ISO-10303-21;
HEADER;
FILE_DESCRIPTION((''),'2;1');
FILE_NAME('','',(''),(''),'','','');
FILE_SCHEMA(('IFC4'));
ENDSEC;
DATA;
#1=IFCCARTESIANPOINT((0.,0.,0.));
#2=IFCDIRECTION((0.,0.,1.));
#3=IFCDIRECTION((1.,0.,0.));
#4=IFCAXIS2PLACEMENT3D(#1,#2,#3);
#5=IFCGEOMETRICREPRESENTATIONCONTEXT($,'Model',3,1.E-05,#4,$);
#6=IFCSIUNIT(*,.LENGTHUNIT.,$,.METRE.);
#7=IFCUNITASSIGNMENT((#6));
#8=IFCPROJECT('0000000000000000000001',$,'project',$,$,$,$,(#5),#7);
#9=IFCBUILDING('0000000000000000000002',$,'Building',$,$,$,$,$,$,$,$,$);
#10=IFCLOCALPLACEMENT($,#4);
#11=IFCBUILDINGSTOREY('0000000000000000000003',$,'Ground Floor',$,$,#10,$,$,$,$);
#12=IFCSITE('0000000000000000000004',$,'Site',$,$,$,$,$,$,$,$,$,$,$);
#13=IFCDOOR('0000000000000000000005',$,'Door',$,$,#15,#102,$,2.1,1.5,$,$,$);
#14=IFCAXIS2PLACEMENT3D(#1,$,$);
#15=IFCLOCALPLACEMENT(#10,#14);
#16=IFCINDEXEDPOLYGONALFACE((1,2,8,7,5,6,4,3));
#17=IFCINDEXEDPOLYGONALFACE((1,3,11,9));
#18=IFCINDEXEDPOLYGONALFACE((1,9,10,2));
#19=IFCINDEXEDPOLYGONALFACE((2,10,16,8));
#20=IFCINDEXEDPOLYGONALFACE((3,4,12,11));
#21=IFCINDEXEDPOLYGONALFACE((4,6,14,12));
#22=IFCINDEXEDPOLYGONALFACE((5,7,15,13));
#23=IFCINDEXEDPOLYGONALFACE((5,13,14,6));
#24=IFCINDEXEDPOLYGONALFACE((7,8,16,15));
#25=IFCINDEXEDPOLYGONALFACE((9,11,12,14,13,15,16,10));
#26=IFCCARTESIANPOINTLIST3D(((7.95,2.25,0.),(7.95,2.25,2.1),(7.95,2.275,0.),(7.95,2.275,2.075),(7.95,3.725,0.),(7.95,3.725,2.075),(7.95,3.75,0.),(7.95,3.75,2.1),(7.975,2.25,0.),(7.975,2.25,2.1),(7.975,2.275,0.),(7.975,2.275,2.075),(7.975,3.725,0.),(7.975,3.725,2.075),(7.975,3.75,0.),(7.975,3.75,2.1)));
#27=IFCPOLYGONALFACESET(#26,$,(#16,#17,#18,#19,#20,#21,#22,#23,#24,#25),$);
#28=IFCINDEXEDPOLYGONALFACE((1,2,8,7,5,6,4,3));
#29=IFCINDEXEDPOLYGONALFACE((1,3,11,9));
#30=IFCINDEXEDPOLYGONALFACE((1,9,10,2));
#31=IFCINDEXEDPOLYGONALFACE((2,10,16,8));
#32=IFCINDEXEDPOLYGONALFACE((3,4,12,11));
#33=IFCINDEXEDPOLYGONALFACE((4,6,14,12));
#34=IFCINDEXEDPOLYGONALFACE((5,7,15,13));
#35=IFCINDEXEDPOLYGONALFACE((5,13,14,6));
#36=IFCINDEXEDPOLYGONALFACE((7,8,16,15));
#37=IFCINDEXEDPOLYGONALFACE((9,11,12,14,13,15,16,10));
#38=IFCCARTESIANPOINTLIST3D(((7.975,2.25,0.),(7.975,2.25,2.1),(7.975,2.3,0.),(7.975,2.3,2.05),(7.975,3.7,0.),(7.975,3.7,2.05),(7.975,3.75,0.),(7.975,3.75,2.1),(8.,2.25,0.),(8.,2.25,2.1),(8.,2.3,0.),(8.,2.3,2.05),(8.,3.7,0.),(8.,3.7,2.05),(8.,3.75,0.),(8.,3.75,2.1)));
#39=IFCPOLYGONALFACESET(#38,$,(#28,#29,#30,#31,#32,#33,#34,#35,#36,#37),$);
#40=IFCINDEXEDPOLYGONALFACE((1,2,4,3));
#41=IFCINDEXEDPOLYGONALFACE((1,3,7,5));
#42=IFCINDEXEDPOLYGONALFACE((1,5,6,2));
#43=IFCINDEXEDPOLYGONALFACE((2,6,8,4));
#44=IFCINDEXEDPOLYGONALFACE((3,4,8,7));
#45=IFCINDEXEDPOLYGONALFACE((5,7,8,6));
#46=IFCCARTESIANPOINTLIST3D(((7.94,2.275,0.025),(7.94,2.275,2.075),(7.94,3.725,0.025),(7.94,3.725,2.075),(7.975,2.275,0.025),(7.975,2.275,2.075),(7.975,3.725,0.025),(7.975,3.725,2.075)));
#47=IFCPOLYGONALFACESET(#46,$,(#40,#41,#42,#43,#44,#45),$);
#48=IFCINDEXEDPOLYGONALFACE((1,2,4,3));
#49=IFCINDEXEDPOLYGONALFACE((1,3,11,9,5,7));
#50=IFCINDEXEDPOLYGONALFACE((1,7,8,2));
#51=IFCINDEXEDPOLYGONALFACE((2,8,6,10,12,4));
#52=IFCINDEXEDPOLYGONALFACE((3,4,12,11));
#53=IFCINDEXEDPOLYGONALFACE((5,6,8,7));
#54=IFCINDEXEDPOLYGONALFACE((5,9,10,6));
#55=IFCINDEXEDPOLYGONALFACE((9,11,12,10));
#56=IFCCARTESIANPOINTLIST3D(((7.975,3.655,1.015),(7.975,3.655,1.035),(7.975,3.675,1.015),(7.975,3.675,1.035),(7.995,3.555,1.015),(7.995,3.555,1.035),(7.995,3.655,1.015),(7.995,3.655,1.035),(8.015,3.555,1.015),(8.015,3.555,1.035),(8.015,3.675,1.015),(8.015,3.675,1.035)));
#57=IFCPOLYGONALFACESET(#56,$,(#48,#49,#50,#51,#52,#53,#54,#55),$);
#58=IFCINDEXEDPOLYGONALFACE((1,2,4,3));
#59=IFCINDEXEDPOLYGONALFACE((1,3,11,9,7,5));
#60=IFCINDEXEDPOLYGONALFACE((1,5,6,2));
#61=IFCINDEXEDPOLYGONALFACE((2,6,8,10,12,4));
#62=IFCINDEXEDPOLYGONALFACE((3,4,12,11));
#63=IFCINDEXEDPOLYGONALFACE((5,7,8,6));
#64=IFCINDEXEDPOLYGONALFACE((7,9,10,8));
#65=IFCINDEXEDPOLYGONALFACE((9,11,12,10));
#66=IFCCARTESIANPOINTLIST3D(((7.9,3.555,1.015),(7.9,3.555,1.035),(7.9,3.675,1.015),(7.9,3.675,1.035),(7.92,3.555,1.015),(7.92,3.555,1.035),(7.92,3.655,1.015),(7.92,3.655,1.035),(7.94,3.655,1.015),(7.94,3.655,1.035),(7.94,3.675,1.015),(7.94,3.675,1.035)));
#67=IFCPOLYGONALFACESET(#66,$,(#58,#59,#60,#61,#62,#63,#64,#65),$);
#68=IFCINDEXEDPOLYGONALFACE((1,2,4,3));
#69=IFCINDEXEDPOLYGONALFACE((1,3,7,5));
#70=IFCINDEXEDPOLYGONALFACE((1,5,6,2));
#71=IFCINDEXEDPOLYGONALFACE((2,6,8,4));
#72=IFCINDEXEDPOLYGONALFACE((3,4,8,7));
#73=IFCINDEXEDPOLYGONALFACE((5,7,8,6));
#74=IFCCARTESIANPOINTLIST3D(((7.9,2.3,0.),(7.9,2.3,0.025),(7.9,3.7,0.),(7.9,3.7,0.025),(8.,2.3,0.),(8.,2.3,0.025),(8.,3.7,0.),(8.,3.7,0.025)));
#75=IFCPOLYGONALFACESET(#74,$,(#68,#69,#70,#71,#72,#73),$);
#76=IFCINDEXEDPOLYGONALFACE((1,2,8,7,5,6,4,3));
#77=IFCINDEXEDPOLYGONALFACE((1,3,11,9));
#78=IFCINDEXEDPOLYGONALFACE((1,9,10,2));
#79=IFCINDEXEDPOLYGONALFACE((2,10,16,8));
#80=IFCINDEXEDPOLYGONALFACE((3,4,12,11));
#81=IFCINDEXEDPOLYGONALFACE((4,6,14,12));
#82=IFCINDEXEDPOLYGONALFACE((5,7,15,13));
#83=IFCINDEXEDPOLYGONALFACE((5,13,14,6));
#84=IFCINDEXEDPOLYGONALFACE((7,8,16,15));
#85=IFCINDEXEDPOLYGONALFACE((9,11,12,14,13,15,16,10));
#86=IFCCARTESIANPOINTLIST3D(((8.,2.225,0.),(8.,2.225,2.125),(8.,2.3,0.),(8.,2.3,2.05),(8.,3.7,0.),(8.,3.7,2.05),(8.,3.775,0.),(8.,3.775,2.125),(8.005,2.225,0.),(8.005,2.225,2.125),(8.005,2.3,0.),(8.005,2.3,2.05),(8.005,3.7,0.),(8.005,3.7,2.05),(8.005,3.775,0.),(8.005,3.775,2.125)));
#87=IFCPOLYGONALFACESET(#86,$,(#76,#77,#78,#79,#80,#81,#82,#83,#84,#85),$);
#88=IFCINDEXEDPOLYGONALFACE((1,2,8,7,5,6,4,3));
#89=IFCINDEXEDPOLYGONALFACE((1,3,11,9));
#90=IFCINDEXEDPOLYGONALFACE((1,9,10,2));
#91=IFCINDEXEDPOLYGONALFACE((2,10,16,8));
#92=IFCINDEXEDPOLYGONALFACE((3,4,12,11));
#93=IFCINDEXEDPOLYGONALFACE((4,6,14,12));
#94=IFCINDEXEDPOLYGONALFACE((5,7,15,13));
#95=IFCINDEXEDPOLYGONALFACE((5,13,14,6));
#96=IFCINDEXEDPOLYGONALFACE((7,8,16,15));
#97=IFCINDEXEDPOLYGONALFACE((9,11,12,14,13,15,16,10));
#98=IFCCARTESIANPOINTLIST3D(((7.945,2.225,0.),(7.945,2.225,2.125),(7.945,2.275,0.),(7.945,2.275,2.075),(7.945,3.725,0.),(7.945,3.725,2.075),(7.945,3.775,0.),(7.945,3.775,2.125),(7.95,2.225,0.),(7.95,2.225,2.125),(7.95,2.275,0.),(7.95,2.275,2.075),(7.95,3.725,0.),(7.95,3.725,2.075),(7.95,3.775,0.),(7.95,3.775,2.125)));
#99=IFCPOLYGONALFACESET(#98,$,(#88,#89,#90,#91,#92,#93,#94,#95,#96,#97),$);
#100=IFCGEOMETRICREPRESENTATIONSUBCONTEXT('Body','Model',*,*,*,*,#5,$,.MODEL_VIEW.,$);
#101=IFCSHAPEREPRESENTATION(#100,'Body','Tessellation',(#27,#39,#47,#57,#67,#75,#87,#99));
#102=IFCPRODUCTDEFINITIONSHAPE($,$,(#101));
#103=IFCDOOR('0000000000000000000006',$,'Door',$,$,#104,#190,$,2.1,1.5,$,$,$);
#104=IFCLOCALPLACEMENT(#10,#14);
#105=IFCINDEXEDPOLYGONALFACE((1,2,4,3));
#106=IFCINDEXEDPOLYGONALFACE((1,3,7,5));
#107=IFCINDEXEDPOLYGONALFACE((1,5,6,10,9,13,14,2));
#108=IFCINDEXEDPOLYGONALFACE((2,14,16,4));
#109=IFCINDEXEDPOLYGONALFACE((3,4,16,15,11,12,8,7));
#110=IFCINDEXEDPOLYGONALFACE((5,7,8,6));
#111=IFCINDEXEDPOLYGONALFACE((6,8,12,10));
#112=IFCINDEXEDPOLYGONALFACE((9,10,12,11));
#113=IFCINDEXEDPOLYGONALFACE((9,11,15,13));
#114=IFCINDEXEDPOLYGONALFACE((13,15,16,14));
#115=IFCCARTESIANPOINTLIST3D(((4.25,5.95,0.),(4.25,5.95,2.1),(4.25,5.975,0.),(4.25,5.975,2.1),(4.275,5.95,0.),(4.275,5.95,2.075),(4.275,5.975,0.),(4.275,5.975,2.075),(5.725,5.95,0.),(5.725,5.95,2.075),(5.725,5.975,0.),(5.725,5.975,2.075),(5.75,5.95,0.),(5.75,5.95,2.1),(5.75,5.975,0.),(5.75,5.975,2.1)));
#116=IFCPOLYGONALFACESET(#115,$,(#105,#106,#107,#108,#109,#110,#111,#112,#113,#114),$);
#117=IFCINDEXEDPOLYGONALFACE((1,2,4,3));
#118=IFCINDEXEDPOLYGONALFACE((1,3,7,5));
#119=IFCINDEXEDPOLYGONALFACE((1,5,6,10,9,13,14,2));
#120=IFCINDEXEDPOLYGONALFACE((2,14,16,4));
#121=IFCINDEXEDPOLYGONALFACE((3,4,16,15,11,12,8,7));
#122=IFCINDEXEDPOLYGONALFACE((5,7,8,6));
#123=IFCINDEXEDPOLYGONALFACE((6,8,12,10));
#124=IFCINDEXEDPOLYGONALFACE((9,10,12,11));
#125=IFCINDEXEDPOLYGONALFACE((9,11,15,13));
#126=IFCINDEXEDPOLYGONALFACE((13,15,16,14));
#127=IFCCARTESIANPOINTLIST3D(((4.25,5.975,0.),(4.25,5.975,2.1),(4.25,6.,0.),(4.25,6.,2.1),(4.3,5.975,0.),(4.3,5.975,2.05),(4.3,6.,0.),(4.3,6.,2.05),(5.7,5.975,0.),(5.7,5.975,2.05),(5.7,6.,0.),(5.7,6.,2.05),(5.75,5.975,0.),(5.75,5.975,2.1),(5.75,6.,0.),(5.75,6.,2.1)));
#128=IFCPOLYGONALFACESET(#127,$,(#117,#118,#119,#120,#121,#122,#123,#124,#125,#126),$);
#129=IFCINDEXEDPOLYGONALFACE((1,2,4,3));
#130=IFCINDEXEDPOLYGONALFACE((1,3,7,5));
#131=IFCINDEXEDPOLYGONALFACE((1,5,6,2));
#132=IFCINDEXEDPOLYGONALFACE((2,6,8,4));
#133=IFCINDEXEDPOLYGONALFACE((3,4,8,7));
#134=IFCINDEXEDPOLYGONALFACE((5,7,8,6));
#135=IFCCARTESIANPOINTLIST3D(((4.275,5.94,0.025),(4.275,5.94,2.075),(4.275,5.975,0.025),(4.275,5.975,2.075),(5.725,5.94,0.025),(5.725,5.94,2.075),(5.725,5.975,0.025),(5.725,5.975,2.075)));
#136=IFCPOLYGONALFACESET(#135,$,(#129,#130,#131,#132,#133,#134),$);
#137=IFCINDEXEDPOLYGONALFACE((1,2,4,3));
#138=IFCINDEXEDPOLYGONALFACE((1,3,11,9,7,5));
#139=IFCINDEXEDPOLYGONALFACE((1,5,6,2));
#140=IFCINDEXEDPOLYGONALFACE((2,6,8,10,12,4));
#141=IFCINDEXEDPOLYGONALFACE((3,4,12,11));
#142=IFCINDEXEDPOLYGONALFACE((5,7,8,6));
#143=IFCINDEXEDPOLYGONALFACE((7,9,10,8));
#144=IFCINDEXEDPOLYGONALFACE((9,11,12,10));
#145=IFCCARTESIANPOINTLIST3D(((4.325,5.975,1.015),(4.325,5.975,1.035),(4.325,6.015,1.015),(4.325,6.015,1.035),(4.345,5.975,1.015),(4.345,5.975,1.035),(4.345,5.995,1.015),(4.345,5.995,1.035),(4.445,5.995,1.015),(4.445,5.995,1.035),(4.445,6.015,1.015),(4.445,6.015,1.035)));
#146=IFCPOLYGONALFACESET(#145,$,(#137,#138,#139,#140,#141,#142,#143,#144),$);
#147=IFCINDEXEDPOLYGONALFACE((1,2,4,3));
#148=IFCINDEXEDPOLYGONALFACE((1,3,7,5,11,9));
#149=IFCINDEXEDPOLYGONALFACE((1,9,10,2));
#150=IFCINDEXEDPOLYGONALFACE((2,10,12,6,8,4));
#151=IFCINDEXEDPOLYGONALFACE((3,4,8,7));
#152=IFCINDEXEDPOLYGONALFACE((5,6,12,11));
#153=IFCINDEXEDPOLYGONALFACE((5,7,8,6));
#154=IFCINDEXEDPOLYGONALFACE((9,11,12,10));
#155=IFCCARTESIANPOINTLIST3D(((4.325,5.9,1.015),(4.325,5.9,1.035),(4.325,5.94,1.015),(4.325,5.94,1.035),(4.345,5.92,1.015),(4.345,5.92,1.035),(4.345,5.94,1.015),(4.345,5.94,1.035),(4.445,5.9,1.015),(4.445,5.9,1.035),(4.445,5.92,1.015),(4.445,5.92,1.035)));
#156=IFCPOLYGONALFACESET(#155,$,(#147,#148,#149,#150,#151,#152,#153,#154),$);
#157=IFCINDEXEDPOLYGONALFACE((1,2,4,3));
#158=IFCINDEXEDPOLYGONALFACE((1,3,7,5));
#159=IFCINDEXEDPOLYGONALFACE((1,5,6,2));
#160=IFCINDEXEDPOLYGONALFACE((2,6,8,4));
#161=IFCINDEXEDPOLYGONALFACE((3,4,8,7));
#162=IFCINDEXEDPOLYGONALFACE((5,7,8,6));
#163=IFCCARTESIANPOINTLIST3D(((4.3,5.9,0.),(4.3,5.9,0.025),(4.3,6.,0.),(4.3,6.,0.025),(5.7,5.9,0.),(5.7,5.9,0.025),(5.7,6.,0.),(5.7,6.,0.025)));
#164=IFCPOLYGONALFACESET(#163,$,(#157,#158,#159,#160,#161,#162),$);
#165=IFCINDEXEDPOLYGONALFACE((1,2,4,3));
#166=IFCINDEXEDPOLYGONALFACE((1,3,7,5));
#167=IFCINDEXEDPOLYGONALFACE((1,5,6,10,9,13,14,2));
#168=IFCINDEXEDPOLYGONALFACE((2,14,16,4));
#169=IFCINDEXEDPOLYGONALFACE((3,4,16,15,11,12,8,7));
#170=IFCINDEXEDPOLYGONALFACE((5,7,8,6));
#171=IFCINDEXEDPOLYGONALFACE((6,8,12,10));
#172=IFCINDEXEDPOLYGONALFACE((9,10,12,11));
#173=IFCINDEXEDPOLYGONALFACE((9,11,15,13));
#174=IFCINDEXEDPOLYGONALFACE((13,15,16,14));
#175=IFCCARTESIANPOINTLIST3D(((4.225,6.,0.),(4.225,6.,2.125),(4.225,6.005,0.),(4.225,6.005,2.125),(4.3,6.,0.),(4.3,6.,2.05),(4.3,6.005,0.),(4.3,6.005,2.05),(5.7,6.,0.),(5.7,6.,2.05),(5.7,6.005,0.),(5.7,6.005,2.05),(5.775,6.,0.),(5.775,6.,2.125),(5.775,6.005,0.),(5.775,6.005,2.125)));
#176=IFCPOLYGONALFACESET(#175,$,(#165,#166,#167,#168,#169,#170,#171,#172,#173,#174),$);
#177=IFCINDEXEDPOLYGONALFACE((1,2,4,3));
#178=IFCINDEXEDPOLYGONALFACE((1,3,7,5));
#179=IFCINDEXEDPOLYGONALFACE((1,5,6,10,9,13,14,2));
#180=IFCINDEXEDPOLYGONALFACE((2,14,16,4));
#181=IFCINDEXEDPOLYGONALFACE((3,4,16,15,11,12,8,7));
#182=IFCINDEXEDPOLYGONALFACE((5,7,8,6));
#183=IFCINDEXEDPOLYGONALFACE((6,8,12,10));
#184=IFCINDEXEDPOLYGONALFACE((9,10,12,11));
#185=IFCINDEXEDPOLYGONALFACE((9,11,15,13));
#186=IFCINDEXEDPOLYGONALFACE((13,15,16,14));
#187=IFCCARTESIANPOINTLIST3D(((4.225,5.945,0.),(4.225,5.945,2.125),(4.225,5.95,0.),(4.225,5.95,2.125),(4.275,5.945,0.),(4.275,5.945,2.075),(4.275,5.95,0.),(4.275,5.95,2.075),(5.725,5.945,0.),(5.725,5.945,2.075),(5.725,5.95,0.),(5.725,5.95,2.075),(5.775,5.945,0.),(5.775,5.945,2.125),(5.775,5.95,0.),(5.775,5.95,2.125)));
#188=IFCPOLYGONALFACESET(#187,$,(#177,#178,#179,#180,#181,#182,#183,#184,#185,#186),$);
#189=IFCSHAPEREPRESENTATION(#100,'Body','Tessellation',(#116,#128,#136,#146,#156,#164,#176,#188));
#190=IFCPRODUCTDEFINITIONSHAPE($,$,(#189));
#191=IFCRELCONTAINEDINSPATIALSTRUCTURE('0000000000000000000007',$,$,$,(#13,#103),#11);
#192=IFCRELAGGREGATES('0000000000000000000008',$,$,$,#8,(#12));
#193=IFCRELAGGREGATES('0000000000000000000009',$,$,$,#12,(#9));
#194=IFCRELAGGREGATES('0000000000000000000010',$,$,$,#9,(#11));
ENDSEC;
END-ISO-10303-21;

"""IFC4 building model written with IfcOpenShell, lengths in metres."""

from ifc_helpers import new_model, si_unit, frame, origin_with_axes, place, context, subcontext, project, spatial, line, indexed_curve, outline, extrude, element, save


model = new_model("IFC4")

# Units and contexts
model_context = context("Model", 3, precision=1e-05, world=origin_with_axes())
body_context = subcontext(model_context, "Body", "Model", "MODEL_VIEW")
ifc_project = project(units=[si_unit("LENGTHUNIT", "METRE")], contexts=[model_context])

# Site, building, storey
site = spatial("IfcSite", under=ifc_project, Name="Site")
building = spatial("IfcBuilding", under=site, Name="Building")
storey_placement = place(None, origin_with_axes())
storey = spatial("IfcBuildingStorey", under=building, at=storey_placement, Name="Ground Floor")

# Doors
door_1_placement = place(storey_placement, frame((8.0, 2.25, 0.0), z_axis=(0.0, 0.0, 1.0), x_axis=(0.0, 1.0, 0.0)))
element("IfcDoor", 1, at=door_1_placement, inside=storey, Name="Door", OverallHeight=2.1, OverallWidth=1.5, context=body_context, shape_type="SweptSolid", body=[
    extrude(outline(indexed_curve([(0.0, 0.0), (0.0, 2.1), (1.5, 2.1), (1.5, 0.0), (1.475, 0.0), (1.475, 2.075), (0.025, 2.075), (0.025, 0.0)], segments=[line(1, 2, 3, 4, 5, 6, 7, 8, 1)])), frame((0.0, 0.025, 0.0), z_axis=(0.0, -1.0, 0.0), x_axis=(1.0, 0.0, 0.0)), (0.0, 0.0, -1.0), 0.025),
    extrude(outline(indexed_curve([(0.0, 0.0), (0.0, 2.1), (1.5, 2.1), (1.5, 0.0), (1.45, 0.0), (1.45, 2.05), (0.05, 2.05), (0.05, 0.0)], segments=[line(1, 2, 3, 4, 5, 6, 7, 8, 1)])), frame((0.0, 0.0, 0.0), z_axis=(0.0, -1.0, 0.0), x_axis=(1.0, 0.0, 0.0)), (0.0, 0.0, -1.0), 0.025),
    extrude(outline(indexed_curve([(0.0, 0.0), (1.45, 0.0), (1.45, 0.035), (0.0, 0.035)], segments=[line(1, 2, 3, 4, 1)])), frame((0.025, 0.025, 0.025), z_axis=(0.0, 0.0, 1.0), x_axis=(1.0, 0.0, 0.0)), (0.0, 0.0, 1.0), 2.05),
    extrude(outline(indexed_curve([(0.0, 0.0), (0.0, -0.04), (-0.12, -0.04), (-0.12, -0.02), (-0.02, -0.02), (-0.02, 0.0)], segments=[line(1, 2, 3, 4, 5, 6, 1)])), frame((1.425, 0.025, 1.015), z_axis=(0.0, 0.0, 1.0), x_axis=(1.0, 0.0, 0.0)), (0.0, 0.0, 1.0), 0.02),
    extrude(outline(indexed_curve([(0.0, 0.0), (0.0, 0.04), (-0.12, 0.04), (-0.12, 0.02), (-0.02, 0.02), (-0.02, 0.0)], segments=[line(1, 2, 3, 4, 5, 6, 1)])), frame((1.425, 0.06, 1.015), z_axis=(0.0, 0.0, 1.0), x_axis=(1.0, 0.0, 0.0)), (0.0, 0.0, 1.0), 0.02),
    extrude(outline(indexed_curve([(0.0, 0.0), (1.4, 0.0), (1.4, 0.1), (0.0, 0.1)], segments=[line(1, 2, 3, 4, 1)])), frame((0.05, 0.0, 0.0), z_axis=(0.0, 0.0, 1.0), x_axis=(1.0, 0.0, 0.0)), (0.0, 0.0, 1.0), 0.025),
    extrude(outline(indexed_curve([(0.0, 0.0), (0.0, 2.125), (1.55, 2.125), (1.55, 0.0), (1.475, 0.0), (1.475, 2.05), (0.075, 2.05), (0.075, 0.0)], segments=[line(1, 2, 3, 4, 5, 6, 7, 8, 1)])), frame((-0.025, -0.005, 0.0), z_axis=(0.0, -1.0, 0.0), x_axis=(1.0, 0.0, 0.0)), (0.0, 0.0, -1.0), 0.005),
    extrude(outline(indexed_curve([(0.0, 0.0), (0.0, 2.125), (1.55, 2.125), (1.55, 0.0), (1.5, 0.0), (1.5, 2.075), (0.05, 2.075), (0.05, 0.0)], segments=[line(1, 2, 3, 4, 5, 6, 7, 8, 1)])), frame((-0.025, 0.05, 0.0), z_axis=(0.0, -1.0, 0.0), x_axis=(1.0, 0.0, 0.0)), (0.0, 0.0, -1.0), 0.005),
])
door_2_placement = place(storey_placement, frame((5.75, 6.0, 0.0), z_axis=(0.0, 0.0, 1.0), x_axis=(-1.0, 0.0, 0.0)))
element("IfcDoor", 2, at=door_2_placement, inside=storey, Name="Door", OverallHeight=2.1, OverallWidth=1.5, context=body_context, shape_type="SweptSolid", body=[
    extrude(outline(indexed_curve([(0.0, 0.0), (0.0, 2.1), (1.5, 2.1), (1.5, 0.0), (1.475, 0.0), (1.475, 2.075), (0.025, 2.075), (0.025, 0.0)], segments=[line(1, 2, 3, 4, 5, 6, 7, 8, 1)])), frame((0.0, 0.025, 0.0), z_axis=(0.0, -1.0, 0.0), x_axis=(1.0, 0.0, 0.0)), (0.0, 0.0, -1.0), 0.025),
    extrude(outline(indexed_curve([(0.0, 0.0), (0.0, 2.1), (1.5, 2.1), (1.5, 0.0), (1.45, 0.0), (1.45, 2.05), (0.05, 2.05), (0.05, 0.0)], segments=[line(1, 2, 3, 4, 5, 6, 7, 8, 1)])), frame((0.0, 0.0, 0.0), z_axis=(0.0, -1.0, 0.0), x_axis=(1.0, 0.0, 0.0)), (0.0, 0.0, -1.0), 0.025),
    extrude(outline(indexed_curve([(0.0, 0.0), (1.45, 0.0), (1.45, 0.035), (0.0, 0.035)], segments=[line(1, 2, 3, 4, 1)])), frame((0.025, 0.025, 0.025), z_axis=(0.0, 0.0, 1.0), x_axis=(1.0, 0.0, 0.0)), (0.0, 0.0, 1.0), 2.05),
    extrude(outline(indexed_curve([(0.0, 0.0), (0.0, -0.04), (-0.12, -0.04), (-0.12, -0.02), (-0.02, -0.02), (-0.02, 0.0)], segments=[line(1, 2, 3, 4, 5, 6, 1)])), frame((1.425, 0.025, 1.015), z_axis=(0.0, 0.0, 1.0), x_axis=(1.0, 0.0, 0.0)), (0.0, 0.0, 1.0), 0.02),
    extrude(outline(indexed_curve([(0.0, 0.0), (0.0, 0.04), (-0.12, 0.04), (-0.12, 0.02), (-0.02, 0.02), (-0.02, 0.0)], segments=[line(1, 2, 3, 4, 5, 6, 1)])), frame((1.425, 0.06, 1.015), z_axis=(0.0, 0.0, 1.0), x_axis=(1.0, 0.0, 0.0)), (0.0, 0.0, 1.0), 0.02),
    extrude(outline(indexed_curve([(0.0, 0.0), (1.4, 0.0), (1.4, 0.1), (0.0, 0.1)], segments=[line(1, 2, 3, 4, 1)])), frame((0.05, 0.0, 0.0), z_axis=(0.0, 0.0, 1.0), x_axis=(1.0, 0.0, 0.0)), (0.0, 0.0, 1.0), 0.025),
    extrude(outline(indexed_curve([(0.0, 0.0), (0.0, 2.125), (1.55, 2.125), (1.55, 0.0), (1.475, 0.0), (1.475, 2.05), (0.075, 2.05), (0.075, 0.0)], segments=[line(1, 2, 3, 4, 5, 6, 7, 8, 1)])), frame((-0.025, -0.005, 0.0), z_axis=(0.0, -1.0, 0.0), x_axis=(1.0, 0.0, 0.0)), (0.0, 0.0, -1.0), 0.005),
    extrude(outline(indexed_curve([(0.0, 0.0), (0.0, 2.125), (1.55, 2.125), (1.55, 0.0), (1.5, 0.0), (1.5, 2.075), (0.05, 2.075), (0.05, 0.0)], segments=[line(1, 2, 3, 4, 5, 6, 7, 8, 1)])), frame((-0.025, 0.05, 0.0), z_axis=(0.0, -1.0, 0.0), x_axis=(1.0, 0.0, 0.0)), (0.0, 0.0, -1.0), 0.005),
])

save(model, "model.ifc")
